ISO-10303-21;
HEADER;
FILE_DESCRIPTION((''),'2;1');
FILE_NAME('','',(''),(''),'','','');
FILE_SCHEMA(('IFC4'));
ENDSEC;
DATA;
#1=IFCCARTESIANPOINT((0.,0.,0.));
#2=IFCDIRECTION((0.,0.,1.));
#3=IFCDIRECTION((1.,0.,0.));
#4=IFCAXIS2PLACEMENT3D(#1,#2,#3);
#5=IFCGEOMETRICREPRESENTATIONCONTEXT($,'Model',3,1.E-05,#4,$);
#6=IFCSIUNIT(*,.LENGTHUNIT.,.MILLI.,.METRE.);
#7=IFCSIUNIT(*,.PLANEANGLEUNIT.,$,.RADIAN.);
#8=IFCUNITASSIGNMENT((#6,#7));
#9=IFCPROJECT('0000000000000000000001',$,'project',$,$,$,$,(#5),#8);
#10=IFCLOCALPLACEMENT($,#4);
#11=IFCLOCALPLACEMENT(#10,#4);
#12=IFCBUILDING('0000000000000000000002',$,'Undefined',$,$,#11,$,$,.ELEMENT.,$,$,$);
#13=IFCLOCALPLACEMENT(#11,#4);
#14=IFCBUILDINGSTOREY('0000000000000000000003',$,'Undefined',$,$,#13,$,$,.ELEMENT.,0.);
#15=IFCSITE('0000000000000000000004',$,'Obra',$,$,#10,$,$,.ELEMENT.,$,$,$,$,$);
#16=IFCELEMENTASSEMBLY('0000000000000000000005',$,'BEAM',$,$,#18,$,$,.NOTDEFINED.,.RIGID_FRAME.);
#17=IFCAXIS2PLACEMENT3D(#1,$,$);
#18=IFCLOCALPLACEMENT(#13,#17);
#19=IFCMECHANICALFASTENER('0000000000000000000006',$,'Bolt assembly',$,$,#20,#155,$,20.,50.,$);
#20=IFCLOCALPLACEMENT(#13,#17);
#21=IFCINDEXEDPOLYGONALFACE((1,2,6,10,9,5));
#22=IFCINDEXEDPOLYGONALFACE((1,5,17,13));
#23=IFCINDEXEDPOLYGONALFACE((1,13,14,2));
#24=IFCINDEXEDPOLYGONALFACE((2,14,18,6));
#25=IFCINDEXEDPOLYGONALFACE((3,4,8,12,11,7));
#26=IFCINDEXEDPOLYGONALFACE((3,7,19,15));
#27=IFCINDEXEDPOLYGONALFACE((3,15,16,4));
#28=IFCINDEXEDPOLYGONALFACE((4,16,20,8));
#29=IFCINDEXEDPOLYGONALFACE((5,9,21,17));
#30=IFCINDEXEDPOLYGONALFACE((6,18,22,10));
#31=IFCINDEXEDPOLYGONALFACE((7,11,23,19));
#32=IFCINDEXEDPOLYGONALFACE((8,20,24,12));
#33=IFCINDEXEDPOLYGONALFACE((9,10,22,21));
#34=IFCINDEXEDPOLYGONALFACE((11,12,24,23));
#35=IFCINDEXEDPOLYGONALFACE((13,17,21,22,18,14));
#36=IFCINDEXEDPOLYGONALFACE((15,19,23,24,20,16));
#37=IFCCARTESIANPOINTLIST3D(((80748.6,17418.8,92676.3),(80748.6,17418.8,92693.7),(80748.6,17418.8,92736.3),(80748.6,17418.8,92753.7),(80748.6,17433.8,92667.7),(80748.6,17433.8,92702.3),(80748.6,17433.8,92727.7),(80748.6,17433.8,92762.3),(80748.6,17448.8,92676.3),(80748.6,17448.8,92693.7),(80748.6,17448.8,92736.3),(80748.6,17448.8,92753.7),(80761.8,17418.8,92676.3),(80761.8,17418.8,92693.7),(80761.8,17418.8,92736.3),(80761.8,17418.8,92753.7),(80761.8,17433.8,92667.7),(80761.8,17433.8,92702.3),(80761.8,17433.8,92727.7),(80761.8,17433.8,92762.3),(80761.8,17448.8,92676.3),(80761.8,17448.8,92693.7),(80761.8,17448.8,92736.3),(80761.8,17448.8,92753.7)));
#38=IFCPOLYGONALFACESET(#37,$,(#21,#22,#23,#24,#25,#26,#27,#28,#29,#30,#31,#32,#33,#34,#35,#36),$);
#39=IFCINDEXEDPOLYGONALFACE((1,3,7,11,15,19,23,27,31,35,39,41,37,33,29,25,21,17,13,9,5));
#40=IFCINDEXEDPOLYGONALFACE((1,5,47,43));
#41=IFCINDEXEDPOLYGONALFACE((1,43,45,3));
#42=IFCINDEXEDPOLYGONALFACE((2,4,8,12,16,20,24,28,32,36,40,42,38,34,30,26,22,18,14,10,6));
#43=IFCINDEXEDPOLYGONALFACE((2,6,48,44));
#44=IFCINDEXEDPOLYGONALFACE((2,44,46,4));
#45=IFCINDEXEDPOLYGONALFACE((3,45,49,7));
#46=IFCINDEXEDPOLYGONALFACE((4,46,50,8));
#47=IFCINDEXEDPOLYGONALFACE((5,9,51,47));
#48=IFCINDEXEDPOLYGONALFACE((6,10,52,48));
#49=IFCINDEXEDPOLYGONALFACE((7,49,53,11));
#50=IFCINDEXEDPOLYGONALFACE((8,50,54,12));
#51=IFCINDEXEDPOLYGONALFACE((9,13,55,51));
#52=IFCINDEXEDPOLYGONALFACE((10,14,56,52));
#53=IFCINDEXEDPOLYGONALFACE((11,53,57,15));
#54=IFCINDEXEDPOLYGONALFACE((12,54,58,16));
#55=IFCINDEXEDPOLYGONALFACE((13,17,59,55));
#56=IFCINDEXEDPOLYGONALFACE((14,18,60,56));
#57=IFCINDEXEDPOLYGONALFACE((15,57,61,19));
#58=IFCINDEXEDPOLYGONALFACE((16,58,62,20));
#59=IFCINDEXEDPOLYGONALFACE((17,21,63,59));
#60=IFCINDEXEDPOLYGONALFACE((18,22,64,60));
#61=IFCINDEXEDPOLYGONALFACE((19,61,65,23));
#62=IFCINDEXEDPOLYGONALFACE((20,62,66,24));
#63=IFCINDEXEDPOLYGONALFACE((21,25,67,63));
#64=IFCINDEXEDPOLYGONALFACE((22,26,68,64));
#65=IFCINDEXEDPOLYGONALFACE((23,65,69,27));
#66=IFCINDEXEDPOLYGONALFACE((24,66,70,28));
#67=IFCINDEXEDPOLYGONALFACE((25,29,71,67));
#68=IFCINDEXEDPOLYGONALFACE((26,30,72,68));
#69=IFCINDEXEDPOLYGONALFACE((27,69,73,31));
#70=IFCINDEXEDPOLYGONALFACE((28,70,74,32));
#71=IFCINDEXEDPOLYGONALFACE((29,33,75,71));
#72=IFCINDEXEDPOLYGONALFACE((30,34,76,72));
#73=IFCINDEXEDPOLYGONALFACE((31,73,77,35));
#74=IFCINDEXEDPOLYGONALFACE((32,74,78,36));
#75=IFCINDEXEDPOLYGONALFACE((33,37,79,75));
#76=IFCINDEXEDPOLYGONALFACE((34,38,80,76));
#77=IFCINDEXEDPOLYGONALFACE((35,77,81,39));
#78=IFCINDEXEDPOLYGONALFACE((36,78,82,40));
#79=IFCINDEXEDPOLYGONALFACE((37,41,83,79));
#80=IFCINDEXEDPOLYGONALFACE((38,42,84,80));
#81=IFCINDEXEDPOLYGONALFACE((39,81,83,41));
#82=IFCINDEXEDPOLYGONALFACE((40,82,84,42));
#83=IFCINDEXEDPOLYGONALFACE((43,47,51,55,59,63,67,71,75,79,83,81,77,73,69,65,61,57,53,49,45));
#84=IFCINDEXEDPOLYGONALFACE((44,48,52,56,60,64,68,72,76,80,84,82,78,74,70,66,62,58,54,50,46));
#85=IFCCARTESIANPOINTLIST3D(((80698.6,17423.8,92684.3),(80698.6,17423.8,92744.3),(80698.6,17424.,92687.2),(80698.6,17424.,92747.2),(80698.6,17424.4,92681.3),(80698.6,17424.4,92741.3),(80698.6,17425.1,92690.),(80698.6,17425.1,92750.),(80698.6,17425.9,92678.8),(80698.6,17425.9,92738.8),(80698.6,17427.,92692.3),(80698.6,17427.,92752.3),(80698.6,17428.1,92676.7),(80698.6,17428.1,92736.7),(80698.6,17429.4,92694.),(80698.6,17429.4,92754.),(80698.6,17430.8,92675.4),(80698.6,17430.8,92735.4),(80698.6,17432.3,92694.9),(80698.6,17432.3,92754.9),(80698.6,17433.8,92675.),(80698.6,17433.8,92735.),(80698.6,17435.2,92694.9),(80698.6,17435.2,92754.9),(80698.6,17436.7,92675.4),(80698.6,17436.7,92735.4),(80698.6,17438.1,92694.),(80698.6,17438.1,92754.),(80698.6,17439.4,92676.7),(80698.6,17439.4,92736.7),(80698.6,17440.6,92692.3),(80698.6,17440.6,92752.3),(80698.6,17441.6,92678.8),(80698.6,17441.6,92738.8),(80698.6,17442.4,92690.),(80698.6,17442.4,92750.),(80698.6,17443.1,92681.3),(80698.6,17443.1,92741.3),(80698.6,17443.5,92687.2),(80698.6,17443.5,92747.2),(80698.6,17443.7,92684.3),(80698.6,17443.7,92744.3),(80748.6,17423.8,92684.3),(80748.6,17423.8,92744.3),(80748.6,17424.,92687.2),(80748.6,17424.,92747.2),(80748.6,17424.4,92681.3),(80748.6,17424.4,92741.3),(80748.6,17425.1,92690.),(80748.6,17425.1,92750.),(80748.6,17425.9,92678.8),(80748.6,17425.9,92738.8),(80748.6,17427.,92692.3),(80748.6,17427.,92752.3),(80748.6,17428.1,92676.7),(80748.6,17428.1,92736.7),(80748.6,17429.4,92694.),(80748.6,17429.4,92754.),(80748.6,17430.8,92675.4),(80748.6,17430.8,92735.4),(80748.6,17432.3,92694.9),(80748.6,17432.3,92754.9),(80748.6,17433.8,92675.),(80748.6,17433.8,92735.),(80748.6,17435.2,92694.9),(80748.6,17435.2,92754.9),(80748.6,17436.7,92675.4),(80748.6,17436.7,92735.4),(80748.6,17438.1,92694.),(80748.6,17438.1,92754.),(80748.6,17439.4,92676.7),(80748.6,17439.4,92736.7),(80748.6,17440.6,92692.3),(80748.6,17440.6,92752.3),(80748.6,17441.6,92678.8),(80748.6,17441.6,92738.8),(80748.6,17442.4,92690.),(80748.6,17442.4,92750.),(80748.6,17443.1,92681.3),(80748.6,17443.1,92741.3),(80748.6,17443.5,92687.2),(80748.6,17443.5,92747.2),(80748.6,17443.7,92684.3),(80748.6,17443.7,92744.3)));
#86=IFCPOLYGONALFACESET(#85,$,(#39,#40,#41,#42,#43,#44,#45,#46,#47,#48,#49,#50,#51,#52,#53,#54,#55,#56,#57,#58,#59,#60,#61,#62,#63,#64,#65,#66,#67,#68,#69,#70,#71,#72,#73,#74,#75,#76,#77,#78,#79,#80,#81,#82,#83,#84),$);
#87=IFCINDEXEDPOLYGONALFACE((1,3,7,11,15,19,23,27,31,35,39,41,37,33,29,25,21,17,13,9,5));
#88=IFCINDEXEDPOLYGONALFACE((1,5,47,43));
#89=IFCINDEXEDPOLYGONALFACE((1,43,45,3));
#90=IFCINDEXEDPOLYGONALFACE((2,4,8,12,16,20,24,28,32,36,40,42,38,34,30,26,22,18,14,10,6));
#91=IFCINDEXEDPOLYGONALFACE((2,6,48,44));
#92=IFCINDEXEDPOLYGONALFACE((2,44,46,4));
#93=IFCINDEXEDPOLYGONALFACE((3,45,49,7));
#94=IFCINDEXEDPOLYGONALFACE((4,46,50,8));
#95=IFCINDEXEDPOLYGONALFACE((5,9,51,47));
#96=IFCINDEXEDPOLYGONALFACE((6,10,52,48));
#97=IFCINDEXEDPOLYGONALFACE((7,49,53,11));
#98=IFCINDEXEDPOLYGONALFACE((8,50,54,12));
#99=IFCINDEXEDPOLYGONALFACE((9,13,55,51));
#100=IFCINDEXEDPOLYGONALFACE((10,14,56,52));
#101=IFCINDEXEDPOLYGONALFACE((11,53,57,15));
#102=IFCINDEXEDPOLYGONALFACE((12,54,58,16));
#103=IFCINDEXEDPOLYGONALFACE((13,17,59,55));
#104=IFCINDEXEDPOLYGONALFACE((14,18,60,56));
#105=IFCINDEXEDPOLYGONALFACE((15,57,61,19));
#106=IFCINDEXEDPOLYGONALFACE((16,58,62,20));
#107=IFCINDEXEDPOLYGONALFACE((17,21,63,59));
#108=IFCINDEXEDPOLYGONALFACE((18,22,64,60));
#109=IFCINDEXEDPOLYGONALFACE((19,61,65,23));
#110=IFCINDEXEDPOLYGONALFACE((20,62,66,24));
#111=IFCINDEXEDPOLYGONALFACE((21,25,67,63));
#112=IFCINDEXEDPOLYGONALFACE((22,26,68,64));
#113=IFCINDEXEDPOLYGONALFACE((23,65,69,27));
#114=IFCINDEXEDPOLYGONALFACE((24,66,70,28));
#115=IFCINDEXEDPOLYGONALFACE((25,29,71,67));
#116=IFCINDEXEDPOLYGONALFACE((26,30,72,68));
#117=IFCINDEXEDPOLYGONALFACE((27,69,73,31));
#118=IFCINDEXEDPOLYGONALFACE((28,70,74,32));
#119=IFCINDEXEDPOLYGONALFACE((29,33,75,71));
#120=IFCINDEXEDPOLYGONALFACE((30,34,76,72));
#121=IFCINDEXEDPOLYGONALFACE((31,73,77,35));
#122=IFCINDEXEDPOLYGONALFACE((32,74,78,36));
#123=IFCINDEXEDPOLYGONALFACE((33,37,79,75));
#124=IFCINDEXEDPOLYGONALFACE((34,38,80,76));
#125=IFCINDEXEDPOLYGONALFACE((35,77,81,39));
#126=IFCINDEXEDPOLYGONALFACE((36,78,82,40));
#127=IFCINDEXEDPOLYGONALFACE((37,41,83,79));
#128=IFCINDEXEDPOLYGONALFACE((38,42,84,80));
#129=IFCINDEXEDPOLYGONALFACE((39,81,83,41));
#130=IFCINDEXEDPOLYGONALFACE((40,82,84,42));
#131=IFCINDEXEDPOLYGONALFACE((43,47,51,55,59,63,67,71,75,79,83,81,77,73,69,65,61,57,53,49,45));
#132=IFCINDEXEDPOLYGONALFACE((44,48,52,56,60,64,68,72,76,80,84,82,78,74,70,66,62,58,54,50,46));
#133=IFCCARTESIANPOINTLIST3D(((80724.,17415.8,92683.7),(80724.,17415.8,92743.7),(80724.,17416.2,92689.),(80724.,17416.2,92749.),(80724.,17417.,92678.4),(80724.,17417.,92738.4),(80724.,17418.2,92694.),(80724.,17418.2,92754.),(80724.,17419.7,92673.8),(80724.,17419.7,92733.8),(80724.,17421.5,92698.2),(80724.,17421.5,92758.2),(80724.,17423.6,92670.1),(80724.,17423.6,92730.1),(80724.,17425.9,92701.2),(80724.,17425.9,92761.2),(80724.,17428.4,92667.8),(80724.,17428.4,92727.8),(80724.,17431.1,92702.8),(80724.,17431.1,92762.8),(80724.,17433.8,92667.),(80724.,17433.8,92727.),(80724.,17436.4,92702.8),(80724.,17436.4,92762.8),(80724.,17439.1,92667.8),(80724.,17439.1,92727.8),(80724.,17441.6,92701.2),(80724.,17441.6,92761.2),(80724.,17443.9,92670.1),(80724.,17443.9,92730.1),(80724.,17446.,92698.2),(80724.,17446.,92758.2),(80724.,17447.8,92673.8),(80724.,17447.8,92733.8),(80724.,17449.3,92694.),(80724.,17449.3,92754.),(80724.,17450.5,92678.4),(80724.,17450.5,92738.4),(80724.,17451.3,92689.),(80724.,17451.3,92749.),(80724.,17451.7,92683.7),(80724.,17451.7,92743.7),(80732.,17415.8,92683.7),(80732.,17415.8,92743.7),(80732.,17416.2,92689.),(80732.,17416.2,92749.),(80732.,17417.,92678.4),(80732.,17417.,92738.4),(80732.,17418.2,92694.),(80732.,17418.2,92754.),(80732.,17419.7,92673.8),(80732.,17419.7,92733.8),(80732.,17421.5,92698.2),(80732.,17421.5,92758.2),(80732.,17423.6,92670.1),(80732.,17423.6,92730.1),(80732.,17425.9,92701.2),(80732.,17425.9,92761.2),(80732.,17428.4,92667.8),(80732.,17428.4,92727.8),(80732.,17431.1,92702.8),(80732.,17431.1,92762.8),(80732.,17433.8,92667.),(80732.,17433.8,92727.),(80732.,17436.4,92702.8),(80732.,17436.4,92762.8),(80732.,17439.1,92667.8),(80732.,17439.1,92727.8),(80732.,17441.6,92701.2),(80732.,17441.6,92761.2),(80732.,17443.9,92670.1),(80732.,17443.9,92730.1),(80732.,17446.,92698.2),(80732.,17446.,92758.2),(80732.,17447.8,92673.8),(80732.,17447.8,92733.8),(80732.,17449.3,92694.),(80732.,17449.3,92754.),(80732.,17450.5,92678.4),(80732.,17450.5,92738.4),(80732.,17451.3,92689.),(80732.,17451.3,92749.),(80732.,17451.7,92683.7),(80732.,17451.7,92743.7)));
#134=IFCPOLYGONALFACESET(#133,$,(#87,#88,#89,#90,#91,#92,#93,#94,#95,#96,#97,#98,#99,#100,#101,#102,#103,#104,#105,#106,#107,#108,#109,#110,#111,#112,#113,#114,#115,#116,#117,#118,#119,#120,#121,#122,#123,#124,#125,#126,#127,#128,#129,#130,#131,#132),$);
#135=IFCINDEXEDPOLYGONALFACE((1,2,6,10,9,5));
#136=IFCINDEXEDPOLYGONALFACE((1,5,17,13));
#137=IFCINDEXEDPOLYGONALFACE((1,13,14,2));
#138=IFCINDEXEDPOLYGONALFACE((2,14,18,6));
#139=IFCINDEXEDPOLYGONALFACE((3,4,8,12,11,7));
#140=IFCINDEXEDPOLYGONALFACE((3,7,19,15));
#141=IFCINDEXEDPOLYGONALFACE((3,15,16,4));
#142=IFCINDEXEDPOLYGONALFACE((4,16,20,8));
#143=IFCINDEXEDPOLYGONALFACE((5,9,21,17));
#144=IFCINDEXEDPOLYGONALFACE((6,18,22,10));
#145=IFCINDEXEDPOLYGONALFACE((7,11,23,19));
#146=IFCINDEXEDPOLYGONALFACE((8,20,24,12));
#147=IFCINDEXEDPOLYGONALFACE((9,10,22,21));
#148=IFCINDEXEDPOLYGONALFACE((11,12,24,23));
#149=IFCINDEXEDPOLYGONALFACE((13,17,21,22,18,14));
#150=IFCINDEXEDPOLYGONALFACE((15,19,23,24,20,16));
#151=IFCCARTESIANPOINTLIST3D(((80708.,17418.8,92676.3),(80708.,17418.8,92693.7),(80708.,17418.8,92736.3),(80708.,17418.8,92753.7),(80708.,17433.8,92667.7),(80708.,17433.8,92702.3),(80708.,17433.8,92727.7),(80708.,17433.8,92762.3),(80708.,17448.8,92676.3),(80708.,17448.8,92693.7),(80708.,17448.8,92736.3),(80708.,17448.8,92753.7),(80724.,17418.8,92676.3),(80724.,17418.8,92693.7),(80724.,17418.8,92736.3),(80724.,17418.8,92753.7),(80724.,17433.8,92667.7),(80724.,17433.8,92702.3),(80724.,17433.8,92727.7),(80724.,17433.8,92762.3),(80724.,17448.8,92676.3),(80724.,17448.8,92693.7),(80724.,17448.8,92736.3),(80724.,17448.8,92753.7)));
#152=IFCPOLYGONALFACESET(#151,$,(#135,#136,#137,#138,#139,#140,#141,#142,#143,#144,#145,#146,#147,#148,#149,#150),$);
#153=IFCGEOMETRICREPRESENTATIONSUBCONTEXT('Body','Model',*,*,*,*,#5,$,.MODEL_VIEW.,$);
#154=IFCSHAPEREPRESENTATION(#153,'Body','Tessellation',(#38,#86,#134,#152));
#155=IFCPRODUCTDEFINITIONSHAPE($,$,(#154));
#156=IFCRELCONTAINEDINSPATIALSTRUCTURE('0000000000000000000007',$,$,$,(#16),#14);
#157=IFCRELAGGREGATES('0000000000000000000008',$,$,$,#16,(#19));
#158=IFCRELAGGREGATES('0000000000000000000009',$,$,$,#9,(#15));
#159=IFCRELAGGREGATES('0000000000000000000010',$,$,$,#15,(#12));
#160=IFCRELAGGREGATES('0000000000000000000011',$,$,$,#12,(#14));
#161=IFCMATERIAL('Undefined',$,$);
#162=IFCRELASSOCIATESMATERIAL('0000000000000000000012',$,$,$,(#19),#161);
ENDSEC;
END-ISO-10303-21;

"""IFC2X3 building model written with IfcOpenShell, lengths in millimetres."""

from ifc_helpers import new_model, si_unit, frame, origin_with_axes, origin_2d_with_axis, place, context, subcontext, project, spatial, polyline, circle, outline, extrude, source, transform, mapped, material, element, aggregate, save


model = new_model("IFC2X3")

# Units and contexts
model_context = context("Model", 3, precision=1e-05, world=origin_with_axes())
body_context = subcontext(model_context, "Body", "Model", "MODEL_VIEW")
ifc_project = project(units=[si_unit("LENGTHUNIT", "METRE", prefix="MILLI"), si_unit("PLANEANGLEUNIT", "RADIAN")], contexts=[model_context])

# Site, building, storey
site_placement = place(None, origin_with_axes())
site = spatial("IfcSite", under=ifc_project, at=site_placement, Name="Obra", CompositionType="ELEMENT")
building_placement = place(site_placement, origin_with_axes())
building = spatial("IfcBuilding", under=site, at=building_placement, Name="Undefined", CompositionType="ELEMENT")
storey_placement = place(building_placement, origin_with_axes())
storey = spatial("IfcBuildingStorey", under=building, at=storey_placement, Name="Undefined", CompositionType="ELEMENT", Elevation=0.0)

# Element assembly, mechanical fastener
ifc_material_1 = material(Name="Undefined")
shared_shape_1 = source(origin_with_axes(), body_context, "Body", "SweptSolid", [
    extrude(outline(polyline([(17.3, 0.0), (8.7, 15.0), (-8.7, 15.0), (-17.3, 0.0), (-8.7, -15.0), (8.7, -15.0), (17.3, 0.0)])), frame((0.0, -26.5, 0.0), z_axis=(0.0, 1.0, 0.0), x_axis=(1.0, 0.0, 0.0)), (0.0, 0.0, 1.0), 13.2),
    extrude(circle(Radius=10.0, at=origin_2d_with_axis()), frame((0.0, -13.3, 0.0), z_axis=(0.0, 1.0, 0.0), x_axis=(1.0, 0.0, 0.0)), (0.0, 0.0, 1.0), 50.0),
    extrude(circle(Radius=18.0, at=origin_2d_with_axis()), frame((0.0, 3.3, 0.0), z_axis=(0.0, 1.0, 0.0), x_axis=(1.0, 0.0, 0.0)), (0.0, 0.0, 1.0), 8.0),
    extrude(outline(polyline([(17.3, 0.0), (8.7, 15.0), (-8.7, 15.0), (-17.3, 0.0), (-8.7, -15.0), (8.7, -15.0), (17.3, 0.0)])), frame((0.0, 11.3, 0.0), z_axis=(0.0, 1.0, 0.0), x_axis=(1.0, 0.0, 0.0)), (0.0, 0.0, 1.0), 16.0),
])
assembly_1_placement = place(storey_placement, origin_with_axes())
assembly_1 = element("IfcElementAssembly", 1, at=assembly_1_placement, inside=storey, Name="BEAM", AssemblyPlace="NOTDEFINED", PredefinedType="RIGID_FRAME")
mechanical_fastener_1_placement = place(assembly_1_placement, frame((80735.3, 17393.8, 92850.0), z_axis=(0.0, 1.0, 0.0), x_axis=(0.0, 0.0, -1.0)))
mechanical_fastener_1 = element("IfcMechanicalFastener", 2, at=mechanical_fastener_1_placement, material=ifc_material_1, Name="Bolt assembly", NominalDiameter=20.0, NominalLength=50.0, context=body_context, shape_type="MappedRepresentation", body=[
    mapped(shared_shape_1, transform((105.0, 0.0, 40.0))),
    mapped(shared_shape_1, transform((165.0, 0.0, 40.0))),
])

aggregate(assembly_1, [mechanical_fastener_1])

save(model, "model.ifc")
